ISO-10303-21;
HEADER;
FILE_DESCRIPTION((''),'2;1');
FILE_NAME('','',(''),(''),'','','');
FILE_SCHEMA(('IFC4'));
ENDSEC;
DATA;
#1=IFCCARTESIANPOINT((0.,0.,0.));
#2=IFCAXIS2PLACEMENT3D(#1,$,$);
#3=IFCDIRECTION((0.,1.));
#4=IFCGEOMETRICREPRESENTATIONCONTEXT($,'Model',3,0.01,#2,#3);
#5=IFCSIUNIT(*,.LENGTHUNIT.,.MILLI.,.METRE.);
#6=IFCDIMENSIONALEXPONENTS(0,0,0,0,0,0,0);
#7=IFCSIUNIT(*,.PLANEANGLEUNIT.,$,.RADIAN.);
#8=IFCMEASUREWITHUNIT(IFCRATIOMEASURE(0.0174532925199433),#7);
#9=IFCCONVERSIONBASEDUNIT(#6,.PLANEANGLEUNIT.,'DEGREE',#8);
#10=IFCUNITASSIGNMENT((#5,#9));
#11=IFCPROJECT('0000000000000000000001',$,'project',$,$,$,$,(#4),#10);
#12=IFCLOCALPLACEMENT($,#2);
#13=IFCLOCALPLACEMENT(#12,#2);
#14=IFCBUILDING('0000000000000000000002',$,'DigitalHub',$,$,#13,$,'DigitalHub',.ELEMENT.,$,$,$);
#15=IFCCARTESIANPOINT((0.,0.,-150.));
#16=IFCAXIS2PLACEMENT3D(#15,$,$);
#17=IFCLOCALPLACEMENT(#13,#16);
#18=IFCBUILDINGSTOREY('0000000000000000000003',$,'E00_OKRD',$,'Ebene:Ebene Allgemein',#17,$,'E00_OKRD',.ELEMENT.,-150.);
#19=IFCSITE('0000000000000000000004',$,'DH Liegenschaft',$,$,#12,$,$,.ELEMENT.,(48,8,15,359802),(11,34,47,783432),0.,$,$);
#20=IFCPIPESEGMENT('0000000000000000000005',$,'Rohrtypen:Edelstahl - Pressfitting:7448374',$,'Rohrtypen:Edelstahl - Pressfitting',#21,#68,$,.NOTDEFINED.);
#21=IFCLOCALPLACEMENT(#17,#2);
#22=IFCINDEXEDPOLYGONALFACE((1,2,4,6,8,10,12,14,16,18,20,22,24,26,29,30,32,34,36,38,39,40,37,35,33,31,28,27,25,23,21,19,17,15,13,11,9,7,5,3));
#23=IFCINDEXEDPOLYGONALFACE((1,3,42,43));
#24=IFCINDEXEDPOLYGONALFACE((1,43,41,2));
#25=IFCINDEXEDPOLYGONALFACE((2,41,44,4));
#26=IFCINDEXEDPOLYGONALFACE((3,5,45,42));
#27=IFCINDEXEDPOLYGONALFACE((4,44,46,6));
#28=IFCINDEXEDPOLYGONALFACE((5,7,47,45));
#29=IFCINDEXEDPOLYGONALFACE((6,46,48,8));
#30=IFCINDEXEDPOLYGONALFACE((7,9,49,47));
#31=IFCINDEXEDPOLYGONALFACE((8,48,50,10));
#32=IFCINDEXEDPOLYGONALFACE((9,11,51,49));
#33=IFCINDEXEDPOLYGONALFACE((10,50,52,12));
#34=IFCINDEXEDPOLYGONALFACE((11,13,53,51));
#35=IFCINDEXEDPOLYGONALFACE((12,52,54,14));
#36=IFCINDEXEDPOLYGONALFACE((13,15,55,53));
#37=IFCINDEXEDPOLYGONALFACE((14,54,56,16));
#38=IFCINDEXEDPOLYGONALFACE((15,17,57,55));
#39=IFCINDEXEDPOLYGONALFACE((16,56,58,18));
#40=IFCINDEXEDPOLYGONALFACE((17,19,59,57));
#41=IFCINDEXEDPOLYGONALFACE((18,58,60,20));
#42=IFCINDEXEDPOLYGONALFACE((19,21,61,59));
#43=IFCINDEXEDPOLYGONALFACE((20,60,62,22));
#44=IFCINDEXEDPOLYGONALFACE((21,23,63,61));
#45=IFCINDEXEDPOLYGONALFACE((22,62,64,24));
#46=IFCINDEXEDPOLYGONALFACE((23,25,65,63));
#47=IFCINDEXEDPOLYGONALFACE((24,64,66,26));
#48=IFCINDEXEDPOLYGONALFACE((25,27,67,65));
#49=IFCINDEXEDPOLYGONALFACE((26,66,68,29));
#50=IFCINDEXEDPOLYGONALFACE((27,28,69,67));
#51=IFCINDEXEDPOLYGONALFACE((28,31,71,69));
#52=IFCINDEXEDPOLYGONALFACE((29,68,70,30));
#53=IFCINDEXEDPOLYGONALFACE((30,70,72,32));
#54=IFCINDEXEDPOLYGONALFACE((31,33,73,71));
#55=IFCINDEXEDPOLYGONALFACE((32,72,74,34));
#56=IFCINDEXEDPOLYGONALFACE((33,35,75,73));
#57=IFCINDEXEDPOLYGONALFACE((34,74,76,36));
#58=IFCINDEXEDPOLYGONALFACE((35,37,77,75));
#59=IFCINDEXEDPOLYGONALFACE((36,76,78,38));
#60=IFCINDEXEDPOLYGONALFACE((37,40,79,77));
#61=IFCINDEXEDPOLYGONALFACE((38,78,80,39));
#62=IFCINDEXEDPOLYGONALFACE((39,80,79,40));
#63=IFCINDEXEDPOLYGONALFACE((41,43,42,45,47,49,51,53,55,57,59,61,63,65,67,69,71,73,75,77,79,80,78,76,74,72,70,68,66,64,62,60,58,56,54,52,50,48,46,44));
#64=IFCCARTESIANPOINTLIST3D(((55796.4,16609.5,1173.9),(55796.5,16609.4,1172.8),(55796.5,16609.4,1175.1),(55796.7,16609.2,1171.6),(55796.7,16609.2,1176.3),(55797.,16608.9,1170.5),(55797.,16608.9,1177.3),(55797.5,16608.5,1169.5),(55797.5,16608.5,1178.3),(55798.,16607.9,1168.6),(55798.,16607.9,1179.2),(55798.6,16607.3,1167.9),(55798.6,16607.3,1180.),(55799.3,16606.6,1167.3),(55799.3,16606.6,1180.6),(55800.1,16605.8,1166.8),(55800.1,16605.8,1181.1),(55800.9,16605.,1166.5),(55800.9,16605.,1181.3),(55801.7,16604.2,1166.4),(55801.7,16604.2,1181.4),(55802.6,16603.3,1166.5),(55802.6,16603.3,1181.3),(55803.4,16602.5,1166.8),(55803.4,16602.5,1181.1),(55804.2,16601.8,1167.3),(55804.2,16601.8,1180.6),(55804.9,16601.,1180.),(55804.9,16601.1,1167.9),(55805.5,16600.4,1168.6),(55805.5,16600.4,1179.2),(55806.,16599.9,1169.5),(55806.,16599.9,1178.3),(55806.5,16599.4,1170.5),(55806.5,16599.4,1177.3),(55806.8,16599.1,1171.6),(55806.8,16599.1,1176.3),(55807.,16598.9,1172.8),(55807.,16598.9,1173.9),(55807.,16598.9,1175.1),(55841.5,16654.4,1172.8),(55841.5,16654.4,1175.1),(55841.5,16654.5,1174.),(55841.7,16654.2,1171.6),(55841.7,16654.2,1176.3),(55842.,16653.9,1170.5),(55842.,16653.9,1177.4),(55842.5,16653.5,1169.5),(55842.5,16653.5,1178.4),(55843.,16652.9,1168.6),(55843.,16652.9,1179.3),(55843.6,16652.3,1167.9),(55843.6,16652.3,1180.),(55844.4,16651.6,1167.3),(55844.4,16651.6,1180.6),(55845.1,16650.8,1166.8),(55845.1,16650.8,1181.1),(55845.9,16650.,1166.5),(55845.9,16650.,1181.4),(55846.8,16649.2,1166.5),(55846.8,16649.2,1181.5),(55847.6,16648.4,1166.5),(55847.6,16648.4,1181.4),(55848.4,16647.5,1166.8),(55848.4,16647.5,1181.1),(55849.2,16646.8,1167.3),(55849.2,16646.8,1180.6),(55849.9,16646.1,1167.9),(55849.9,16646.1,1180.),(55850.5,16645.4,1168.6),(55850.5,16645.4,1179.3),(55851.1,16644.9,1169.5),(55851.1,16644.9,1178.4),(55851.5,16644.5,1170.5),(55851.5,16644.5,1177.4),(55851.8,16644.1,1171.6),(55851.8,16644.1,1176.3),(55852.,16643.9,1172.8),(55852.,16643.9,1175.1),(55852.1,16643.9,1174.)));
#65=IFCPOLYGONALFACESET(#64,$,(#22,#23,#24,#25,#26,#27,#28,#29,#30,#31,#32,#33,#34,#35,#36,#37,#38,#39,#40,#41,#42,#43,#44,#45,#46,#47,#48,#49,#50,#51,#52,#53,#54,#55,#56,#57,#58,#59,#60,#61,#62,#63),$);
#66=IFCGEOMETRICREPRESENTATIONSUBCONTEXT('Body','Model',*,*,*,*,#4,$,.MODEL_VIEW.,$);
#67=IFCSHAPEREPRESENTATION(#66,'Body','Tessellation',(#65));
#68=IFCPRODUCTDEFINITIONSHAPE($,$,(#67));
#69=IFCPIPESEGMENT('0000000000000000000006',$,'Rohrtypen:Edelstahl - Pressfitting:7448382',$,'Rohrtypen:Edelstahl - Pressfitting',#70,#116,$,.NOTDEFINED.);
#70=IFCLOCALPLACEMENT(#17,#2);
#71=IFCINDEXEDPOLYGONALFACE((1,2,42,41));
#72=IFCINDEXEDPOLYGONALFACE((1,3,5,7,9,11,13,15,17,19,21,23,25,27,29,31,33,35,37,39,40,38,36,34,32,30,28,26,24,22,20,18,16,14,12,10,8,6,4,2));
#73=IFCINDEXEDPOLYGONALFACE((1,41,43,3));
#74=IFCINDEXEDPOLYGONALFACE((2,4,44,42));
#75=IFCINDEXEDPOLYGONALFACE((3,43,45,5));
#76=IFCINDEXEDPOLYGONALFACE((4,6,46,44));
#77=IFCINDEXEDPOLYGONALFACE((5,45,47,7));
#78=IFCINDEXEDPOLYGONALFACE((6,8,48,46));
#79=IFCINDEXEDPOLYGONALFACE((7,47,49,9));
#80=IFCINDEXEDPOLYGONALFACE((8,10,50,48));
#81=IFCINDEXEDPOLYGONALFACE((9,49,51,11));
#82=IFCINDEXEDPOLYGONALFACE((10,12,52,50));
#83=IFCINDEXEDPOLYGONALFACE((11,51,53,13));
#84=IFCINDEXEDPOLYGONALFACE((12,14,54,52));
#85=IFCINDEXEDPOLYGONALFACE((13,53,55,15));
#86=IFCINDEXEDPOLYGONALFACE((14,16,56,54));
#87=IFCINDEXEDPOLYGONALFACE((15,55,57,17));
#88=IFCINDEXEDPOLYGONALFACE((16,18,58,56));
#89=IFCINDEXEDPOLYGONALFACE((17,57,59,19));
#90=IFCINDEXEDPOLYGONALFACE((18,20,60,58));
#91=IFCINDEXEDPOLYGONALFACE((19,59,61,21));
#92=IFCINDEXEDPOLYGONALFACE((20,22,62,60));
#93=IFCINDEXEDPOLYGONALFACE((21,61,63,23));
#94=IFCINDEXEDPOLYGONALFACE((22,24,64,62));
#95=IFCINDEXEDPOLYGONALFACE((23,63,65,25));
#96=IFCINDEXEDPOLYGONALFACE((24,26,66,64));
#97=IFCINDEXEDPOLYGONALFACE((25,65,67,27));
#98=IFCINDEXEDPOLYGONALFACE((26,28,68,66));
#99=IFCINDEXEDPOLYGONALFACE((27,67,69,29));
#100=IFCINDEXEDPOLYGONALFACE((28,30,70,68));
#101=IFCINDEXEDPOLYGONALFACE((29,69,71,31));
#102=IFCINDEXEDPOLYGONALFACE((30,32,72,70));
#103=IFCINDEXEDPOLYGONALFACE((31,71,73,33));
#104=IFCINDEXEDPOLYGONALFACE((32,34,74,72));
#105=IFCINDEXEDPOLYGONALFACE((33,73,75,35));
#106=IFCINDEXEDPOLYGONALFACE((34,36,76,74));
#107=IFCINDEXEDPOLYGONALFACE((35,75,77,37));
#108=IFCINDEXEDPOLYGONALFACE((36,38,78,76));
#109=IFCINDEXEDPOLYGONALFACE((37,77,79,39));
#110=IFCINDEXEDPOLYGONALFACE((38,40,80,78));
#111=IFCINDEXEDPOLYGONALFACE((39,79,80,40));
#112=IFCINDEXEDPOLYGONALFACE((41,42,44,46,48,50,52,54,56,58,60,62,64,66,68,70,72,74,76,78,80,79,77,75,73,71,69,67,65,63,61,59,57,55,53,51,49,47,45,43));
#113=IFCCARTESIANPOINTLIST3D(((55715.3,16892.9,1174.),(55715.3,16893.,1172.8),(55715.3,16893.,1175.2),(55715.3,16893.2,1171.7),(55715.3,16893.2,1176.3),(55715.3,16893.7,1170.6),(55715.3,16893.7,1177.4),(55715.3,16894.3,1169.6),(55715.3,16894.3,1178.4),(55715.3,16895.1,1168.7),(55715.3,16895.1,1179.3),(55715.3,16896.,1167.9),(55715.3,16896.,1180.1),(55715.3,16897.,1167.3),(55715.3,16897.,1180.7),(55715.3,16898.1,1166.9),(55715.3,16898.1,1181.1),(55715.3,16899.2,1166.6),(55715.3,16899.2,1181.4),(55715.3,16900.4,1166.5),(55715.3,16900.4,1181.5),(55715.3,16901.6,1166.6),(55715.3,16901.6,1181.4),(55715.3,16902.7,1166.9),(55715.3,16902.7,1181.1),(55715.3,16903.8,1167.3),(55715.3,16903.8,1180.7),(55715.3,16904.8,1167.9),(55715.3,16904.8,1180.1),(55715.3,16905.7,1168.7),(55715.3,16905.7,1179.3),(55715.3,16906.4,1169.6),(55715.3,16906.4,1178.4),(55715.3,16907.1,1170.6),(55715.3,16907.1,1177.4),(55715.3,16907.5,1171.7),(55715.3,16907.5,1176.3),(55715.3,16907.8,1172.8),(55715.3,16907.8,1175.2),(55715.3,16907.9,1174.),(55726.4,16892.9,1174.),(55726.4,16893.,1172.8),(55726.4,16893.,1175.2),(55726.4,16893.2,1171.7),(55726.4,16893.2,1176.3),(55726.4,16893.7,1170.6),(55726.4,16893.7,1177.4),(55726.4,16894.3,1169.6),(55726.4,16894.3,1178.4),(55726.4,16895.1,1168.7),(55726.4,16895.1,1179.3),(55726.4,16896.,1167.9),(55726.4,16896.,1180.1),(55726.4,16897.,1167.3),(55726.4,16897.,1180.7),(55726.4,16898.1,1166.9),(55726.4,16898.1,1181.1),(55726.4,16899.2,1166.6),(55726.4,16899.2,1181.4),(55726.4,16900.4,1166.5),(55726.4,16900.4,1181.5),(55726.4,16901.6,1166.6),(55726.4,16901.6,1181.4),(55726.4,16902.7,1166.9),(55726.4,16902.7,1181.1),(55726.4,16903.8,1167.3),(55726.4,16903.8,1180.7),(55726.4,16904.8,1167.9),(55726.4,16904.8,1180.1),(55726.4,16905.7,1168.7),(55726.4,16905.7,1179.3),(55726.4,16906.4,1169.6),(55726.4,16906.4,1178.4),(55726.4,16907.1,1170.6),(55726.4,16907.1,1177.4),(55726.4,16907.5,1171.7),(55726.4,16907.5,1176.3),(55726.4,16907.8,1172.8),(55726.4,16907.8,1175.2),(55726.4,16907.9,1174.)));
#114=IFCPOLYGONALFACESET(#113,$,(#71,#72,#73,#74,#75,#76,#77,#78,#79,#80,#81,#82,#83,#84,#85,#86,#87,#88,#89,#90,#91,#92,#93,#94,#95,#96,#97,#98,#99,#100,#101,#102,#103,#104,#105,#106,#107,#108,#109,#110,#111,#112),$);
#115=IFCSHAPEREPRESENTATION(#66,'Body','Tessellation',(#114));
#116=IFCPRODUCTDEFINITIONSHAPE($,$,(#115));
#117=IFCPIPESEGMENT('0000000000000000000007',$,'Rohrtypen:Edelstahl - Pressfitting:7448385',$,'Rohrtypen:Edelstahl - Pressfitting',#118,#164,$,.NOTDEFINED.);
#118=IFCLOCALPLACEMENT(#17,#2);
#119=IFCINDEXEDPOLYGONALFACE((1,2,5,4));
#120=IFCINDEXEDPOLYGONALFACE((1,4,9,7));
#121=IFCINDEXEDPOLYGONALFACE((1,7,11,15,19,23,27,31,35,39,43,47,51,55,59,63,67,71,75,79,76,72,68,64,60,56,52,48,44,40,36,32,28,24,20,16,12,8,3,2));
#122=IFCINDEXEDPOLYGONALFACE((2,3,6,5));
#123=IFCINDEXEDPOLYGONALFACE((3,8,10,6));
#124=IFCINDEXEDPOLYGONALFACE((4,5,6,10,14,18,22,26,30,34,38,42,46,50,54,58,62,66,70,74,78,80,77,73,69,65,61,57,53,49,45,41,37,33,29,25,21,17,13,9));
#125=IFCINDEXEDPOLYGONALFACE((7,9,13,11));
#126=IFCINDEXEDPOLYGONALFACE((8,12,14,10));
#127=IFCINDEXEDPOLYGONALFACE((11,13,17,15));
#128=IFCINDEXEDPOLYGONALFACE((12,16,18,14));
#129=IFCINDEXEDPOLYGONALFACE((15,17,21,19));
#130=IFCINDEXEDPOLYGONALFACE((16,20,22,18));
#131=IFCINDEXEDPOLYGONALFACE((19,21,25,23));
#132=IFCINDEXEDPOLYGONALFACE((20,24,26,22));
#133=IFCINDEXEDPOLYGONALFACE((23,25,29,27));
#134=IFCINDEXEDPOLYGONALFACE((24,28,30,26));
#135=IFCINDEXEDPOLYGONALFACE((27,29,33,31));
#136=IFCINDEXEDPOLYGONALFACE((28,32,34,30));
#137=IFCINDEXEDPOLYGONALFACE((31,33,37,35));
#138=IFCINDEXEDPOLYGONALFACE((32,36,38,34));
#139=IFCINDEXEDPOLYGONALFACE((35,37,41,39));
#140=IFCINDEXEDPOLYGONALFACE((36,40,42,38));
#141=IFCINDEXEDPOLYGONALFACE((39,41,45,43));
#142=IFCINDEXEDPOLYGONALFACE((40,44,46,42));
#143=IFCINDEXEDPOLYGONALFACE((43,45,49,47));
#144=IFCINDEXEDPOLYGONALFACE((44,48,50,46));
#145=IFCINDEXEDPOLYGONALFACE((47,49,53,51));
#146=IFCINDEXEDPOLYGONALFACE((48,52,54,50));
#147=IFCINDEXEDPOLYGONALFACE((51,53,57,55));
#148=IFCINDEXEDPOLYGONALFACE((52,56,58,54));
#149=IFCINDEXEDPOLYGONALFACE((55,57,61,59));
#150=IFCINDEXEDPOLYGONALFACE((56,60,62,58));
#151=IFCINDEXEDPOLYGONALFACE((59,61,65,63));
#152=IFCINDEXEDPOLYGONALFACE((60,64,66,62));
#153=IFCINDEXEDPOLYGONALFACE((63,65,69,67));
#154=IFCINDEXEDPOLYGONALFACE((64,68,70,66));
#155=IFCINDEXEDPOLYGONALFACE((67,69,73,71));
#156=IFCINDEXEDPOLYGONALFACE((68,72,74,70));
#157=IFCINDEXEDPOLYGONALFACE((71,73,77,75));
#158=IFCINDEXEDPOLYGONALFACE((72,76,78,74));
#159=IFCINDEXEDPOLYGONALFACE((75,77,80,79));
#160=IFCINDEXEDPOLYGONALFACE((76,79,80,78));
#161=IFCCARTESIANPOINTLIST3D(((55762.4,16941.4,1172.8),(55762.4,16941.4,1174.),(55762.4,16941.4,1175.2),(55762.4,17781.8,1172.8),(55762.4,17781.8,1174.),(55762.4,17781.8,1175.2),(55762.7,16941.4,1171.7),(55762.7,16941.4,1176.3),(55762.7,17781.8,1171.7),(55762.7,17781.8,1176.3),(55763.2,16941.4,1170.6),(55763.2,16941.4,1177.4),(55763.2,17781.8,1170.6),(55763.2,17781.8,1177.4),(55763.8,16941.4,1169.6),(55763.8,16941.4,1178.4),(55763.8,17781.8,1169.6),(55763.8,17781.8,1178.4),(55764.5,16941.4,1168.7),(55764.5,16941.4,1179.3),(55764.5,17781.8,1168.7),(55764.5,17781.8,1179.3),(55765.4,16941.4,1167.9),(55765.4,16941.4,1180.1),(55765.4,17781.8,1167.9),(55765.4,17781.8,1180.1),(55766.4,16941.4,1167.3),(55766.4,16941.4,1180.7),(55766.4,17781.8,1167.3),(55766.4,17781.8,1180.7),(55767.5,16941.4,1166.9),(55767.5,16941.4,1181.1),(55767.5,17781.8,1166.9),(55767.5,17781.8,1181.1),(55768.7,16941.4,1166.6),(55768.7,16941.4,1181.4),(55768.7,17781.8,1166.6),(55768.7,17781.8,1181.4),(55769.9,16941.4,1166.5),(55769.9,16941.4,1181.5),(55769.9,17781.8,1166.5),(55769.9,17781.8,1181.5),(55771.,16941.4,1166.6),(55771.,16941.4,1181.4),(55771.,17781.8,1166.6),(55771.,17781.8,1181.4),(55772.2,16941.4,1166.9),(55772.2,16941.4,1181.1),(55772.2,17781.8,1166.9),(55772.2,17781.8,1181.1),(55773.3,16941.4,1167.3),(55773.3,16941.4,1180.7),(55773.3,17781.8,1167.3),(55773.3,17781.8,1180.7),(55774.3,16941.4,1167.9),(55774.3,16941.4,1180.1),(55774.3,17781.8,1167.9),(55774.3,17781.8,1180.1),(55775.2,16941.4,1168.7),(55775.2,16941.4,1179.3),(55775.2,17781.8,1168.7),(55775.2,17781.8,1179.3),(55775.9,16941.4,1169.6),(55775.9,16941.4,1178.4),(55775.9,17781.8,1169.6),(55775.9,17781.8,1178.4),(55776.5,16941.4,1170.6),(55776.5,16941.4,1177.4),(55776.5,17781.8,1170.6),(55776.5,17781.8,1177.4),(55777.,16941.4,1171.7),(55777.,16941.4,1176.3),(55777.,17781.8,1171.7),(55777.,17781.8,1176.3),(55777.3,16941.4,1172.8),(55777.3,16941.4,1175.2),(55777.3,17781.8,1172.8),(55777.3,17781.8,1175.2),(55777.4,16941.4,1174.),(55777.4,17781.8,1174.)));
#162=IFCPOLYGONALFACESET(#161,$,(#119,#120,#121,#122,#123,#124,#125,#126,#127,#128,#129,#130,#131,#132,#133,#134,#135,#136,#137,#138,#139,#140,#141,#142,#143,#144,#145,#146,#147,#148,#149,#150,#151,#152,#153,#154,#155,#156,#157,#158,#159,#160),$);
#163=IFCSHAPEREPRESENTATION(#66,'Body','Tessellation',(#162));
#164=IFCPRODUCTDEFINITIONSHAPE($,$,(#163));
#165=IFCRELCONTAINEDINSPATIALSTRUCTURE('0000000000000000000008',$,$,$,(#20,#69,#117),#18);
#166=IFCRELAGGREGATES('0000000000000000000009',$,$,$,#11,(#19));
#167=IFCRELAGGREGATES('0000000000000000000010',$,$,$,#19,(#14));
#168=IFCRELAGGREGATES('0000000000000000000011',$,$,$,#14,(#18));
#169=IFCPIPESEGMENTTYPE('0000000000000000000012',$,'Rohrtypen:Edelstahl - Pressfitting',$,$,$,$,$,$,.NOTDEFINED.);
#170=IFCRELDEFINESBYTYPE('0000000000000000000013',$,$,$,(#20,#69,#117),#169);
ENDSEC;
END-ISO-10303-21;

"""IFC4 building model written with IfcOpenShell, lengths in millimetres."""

from ifc_helpers import new_model, entity, si_unit, converted_unit, direction, frame, origin, place, context, subcontext, project, spatial, indexed_curve, outline, extrude, type_object, element, save


model = new_model("IFC4")

# Units and contexts
model_context = context("Model", 3, precision=0.01, world=origin(), true_north=direction((0.0, 1.0)))
body_context = subcontext(model_context, "Body", "Model", "MODEL_VIEW")
ifc_project = project(units=[si_unit("LENGTHUNIT", "METRE", prefix="MILLI"), converted_unit("PLANEANGLEUNIT", "DEGREE", entity("IfcRatioMeasure", 0.0174532925199433), si_unit("PLANEANGLEUNIT", "RADIAN"), dimensions=[0, 0, 0, 0, 0, 0, 0])], contexts=[model_context])

# Site, building, storey
site_placement = place(None, origin())
site = spatial("IfcSite", under=ifc_project, at=site_placement, Name="DH Liegenschaft", CompositionType="ELEMENT", RefLatitude=(48, 8, 15, 359802), RefLongitude=(11, 34, 47, 783432), RefElevation=0.0)
building_placement = place(site_placement, origin())
building = spatial("IfcBuilding", under=site, at=building_placement, Name="DigitalHub", LongName="DigitalHub", CompositionType="ELEMENT")
storey_placement = place(building_placement, frame((0.0, 0.0, -150.0)))
storey = spatial("IfcBuildingStorey", under=building, at=storey_placement, Name="E00_OKRD", ObjectType="Ebene:Ebene Allgemein", LongName="E00_OKRD", CompositionType="ELEMENT", Elevation=-150.0)

# Pipe segments
pipe_segment_type_1 = type_object("IfcPipeSegmentType", Name="Rohrtypen:Edelstahl - Pressfitting", PredefinedType="NOTDEFINED")
pipe_segment_1_placement = place(storey_placement, frame((55794.8, 16597.3, 1164.8)))
element("IfcPipeSegment", 1, at=pipe_segment_1_placement, inside=storey, type_object=pipe_segment_type_1, Name="Rohrtypen:Edelstahl - Pressfitting:7448374", ObjectType="Rohrtypen:Edelstahl - Pressfitting", PredefinedType="NOTDEFINED", context=body_context, shape_type="SweptSolid", body=[
    extrude(outline(indexed_curve([(7.5, 0.0), (7.4, 1.2), (7.1, 2.3), (6.7, 3.4), (6.1, 4.4), (5.3, 5.3), (4.4, 6.1), (3.4, 6.7), (2.3, 7.1), (1.2, 7.4), (0.0, 7.5), (-1.2, 7.4), (-2.3, 7.1), (-3.4, 6.7), (-4.4, 6.1), (-5.3, 5.3), (-6.1, 4.4), (-6.7, 3.4), (-7.1, 2.3), (-7.4, 1.2), (-7.5, 0.0), (-7.4, -1.2), (-7.1, -2.3), (-6.7, -3.4), (-6.1, -4.4), (-5.3, -5.3), (-4.4, -6.1), (-3.4, -6.7), (-2.3, -7.1), (-1.2, -7.4), (0.0, -7.5), (1.2, -7.4), (2.3, -7.1), (3.4, -6.7), (4.4, -6.1), (5.3, -5.3), (6.1, -4.4), (6.7, -3.4), (7.1, -2.3), (7.4, -1.2), (7.5, 0.0)], self_intersect=False)), frame((6.9, 6.9, 9.1), z_axis=(0.707107, 0.707107, 0.000149), x_axis=(-0.707107, 0.707107, 0.0)), (0.0, 0.0, 1.0), 63.7),
])
pipe_segment_2_placement = place(storey_placement, frame((55715.3, 16891.3, 1164.9)))
element("IfcPipeSegment", 2, at=pipe_segment_2_placement, inside=storey, type_object=pipe_segment_type_1, Name="Rohrtypen:Edelstahl - Pressfitting:7448382", ObjectType="Rohrtypen:Edelstahl - Pressfitting", PredefinedType="NOTDEFINED", context=body_context, shape_type="SweptSolid", body=[
    extrude(outline(indexed_curve([(7.5, 0.0), (7.4, 1.2), (7.1, 2.3), (6.7, 3.4), (6.1, 4.4), (5.3, 5.3), (4.4, 6.1), (3.4, 6.7), (2.3, 7.1), (1.2, 7.4), (0.0, 7.5), (-1.2, 7.4), (-2.3, 7.1), (-3.4, 6.7), (-4.4, 6.1), (-5.3, 5.3), (-6.1, 4.4), (-6.7, 3.4), (-7.1, 2.3), (-7.4, 1.2), (-7.5, 0.0), (-7.4, -1.2), (-7.1, -2.3), (-6.7, -3.4), (-6.1, -4.4), (-5.3, -5.3), (-4.4, -6.1), (-3.4, -6.7), (-2.3, -7.1), (-1.2, -7.4), (0.0, -7.5), (1.2, -7.4), (2.3, -7.1), (3.4, -6.7), (4.4, -6.1), (5.3, -5.3), (6.1, -4.4), (6.7, -3.4), (7.1, -2.3), (7.4, -1.2), (7.5, 0.0)], self_intersect=False)), frame((0.0, 9.1, 9.1), z_axis=(1.0, 0.0, 0.0), x_axis=(0.0, 1.0, 0.0)), (0.0, 0.0, 1.0), 11.1),
])
pipe_segment_3_placement = place(storey_placement, frame((55760.8, 16941.4, 1164.9)))
element("IfcPipeSegment", 3, at=pipe_segment_3_placement, inside=storey, type_object=pipe_segment_type_1, Name="Rohrtypen:Edelstahl - Pressfitting:7448385", ObjectType="Rohrtypen:Edelstahl - Pressfitting", PredefinedType="NOTDEFINED", context=body_context, shape_type="SweptSolid", body=[
    extrude(outline(indexed_curve([(7.5, 0.0), (7.4, 1.2), (7.1, 2.3), (6.7, 3.4), (6.1, 4.4), (5.3, 5.3), (4.4, 6.1), (3.4, 6.7), (2.3, 7.1), (1.2, 7.4), (0.0, 7.5), (-1.2, 7.4), (-2.3, 7.1), (-3.4, 6.7), (-4.4, 6.1), (-5.3, 5.3), (-6.1, 4.4), (-6.7, 3.4), (-7.1, 2.3), (-7.4, 1.2), (-7.5, 0.0), (-7.4, -1.2), (-7.1, -2.3), (-6.7, -3.4), (-6.1, -4.4), (-5.3, -5.3), (-4.4, -6.1), (-3.4, -6.7), (-2.3, -7.1), (-1.2, -7.4), (0.0, -7.5), (1.2, -7.4), (2.3, -7.1), (3.4, -6.7), (4.4, -6.1), (5.3, -5.3), (6.1, -4.4), (6.7, -3.4), (7.1, -2.3), (7.4, -1.2), (7.5, 0.0)], self_intersect=False)), frame((9.1, 0.0, 9.1), z_axis=(0.0, 1.0, 0.000004), x_axis=(-1.0, 0.0, 0.0)), (0.0, 0.0, 1.0), 840.4),
])

save(model, "model.ifc")
